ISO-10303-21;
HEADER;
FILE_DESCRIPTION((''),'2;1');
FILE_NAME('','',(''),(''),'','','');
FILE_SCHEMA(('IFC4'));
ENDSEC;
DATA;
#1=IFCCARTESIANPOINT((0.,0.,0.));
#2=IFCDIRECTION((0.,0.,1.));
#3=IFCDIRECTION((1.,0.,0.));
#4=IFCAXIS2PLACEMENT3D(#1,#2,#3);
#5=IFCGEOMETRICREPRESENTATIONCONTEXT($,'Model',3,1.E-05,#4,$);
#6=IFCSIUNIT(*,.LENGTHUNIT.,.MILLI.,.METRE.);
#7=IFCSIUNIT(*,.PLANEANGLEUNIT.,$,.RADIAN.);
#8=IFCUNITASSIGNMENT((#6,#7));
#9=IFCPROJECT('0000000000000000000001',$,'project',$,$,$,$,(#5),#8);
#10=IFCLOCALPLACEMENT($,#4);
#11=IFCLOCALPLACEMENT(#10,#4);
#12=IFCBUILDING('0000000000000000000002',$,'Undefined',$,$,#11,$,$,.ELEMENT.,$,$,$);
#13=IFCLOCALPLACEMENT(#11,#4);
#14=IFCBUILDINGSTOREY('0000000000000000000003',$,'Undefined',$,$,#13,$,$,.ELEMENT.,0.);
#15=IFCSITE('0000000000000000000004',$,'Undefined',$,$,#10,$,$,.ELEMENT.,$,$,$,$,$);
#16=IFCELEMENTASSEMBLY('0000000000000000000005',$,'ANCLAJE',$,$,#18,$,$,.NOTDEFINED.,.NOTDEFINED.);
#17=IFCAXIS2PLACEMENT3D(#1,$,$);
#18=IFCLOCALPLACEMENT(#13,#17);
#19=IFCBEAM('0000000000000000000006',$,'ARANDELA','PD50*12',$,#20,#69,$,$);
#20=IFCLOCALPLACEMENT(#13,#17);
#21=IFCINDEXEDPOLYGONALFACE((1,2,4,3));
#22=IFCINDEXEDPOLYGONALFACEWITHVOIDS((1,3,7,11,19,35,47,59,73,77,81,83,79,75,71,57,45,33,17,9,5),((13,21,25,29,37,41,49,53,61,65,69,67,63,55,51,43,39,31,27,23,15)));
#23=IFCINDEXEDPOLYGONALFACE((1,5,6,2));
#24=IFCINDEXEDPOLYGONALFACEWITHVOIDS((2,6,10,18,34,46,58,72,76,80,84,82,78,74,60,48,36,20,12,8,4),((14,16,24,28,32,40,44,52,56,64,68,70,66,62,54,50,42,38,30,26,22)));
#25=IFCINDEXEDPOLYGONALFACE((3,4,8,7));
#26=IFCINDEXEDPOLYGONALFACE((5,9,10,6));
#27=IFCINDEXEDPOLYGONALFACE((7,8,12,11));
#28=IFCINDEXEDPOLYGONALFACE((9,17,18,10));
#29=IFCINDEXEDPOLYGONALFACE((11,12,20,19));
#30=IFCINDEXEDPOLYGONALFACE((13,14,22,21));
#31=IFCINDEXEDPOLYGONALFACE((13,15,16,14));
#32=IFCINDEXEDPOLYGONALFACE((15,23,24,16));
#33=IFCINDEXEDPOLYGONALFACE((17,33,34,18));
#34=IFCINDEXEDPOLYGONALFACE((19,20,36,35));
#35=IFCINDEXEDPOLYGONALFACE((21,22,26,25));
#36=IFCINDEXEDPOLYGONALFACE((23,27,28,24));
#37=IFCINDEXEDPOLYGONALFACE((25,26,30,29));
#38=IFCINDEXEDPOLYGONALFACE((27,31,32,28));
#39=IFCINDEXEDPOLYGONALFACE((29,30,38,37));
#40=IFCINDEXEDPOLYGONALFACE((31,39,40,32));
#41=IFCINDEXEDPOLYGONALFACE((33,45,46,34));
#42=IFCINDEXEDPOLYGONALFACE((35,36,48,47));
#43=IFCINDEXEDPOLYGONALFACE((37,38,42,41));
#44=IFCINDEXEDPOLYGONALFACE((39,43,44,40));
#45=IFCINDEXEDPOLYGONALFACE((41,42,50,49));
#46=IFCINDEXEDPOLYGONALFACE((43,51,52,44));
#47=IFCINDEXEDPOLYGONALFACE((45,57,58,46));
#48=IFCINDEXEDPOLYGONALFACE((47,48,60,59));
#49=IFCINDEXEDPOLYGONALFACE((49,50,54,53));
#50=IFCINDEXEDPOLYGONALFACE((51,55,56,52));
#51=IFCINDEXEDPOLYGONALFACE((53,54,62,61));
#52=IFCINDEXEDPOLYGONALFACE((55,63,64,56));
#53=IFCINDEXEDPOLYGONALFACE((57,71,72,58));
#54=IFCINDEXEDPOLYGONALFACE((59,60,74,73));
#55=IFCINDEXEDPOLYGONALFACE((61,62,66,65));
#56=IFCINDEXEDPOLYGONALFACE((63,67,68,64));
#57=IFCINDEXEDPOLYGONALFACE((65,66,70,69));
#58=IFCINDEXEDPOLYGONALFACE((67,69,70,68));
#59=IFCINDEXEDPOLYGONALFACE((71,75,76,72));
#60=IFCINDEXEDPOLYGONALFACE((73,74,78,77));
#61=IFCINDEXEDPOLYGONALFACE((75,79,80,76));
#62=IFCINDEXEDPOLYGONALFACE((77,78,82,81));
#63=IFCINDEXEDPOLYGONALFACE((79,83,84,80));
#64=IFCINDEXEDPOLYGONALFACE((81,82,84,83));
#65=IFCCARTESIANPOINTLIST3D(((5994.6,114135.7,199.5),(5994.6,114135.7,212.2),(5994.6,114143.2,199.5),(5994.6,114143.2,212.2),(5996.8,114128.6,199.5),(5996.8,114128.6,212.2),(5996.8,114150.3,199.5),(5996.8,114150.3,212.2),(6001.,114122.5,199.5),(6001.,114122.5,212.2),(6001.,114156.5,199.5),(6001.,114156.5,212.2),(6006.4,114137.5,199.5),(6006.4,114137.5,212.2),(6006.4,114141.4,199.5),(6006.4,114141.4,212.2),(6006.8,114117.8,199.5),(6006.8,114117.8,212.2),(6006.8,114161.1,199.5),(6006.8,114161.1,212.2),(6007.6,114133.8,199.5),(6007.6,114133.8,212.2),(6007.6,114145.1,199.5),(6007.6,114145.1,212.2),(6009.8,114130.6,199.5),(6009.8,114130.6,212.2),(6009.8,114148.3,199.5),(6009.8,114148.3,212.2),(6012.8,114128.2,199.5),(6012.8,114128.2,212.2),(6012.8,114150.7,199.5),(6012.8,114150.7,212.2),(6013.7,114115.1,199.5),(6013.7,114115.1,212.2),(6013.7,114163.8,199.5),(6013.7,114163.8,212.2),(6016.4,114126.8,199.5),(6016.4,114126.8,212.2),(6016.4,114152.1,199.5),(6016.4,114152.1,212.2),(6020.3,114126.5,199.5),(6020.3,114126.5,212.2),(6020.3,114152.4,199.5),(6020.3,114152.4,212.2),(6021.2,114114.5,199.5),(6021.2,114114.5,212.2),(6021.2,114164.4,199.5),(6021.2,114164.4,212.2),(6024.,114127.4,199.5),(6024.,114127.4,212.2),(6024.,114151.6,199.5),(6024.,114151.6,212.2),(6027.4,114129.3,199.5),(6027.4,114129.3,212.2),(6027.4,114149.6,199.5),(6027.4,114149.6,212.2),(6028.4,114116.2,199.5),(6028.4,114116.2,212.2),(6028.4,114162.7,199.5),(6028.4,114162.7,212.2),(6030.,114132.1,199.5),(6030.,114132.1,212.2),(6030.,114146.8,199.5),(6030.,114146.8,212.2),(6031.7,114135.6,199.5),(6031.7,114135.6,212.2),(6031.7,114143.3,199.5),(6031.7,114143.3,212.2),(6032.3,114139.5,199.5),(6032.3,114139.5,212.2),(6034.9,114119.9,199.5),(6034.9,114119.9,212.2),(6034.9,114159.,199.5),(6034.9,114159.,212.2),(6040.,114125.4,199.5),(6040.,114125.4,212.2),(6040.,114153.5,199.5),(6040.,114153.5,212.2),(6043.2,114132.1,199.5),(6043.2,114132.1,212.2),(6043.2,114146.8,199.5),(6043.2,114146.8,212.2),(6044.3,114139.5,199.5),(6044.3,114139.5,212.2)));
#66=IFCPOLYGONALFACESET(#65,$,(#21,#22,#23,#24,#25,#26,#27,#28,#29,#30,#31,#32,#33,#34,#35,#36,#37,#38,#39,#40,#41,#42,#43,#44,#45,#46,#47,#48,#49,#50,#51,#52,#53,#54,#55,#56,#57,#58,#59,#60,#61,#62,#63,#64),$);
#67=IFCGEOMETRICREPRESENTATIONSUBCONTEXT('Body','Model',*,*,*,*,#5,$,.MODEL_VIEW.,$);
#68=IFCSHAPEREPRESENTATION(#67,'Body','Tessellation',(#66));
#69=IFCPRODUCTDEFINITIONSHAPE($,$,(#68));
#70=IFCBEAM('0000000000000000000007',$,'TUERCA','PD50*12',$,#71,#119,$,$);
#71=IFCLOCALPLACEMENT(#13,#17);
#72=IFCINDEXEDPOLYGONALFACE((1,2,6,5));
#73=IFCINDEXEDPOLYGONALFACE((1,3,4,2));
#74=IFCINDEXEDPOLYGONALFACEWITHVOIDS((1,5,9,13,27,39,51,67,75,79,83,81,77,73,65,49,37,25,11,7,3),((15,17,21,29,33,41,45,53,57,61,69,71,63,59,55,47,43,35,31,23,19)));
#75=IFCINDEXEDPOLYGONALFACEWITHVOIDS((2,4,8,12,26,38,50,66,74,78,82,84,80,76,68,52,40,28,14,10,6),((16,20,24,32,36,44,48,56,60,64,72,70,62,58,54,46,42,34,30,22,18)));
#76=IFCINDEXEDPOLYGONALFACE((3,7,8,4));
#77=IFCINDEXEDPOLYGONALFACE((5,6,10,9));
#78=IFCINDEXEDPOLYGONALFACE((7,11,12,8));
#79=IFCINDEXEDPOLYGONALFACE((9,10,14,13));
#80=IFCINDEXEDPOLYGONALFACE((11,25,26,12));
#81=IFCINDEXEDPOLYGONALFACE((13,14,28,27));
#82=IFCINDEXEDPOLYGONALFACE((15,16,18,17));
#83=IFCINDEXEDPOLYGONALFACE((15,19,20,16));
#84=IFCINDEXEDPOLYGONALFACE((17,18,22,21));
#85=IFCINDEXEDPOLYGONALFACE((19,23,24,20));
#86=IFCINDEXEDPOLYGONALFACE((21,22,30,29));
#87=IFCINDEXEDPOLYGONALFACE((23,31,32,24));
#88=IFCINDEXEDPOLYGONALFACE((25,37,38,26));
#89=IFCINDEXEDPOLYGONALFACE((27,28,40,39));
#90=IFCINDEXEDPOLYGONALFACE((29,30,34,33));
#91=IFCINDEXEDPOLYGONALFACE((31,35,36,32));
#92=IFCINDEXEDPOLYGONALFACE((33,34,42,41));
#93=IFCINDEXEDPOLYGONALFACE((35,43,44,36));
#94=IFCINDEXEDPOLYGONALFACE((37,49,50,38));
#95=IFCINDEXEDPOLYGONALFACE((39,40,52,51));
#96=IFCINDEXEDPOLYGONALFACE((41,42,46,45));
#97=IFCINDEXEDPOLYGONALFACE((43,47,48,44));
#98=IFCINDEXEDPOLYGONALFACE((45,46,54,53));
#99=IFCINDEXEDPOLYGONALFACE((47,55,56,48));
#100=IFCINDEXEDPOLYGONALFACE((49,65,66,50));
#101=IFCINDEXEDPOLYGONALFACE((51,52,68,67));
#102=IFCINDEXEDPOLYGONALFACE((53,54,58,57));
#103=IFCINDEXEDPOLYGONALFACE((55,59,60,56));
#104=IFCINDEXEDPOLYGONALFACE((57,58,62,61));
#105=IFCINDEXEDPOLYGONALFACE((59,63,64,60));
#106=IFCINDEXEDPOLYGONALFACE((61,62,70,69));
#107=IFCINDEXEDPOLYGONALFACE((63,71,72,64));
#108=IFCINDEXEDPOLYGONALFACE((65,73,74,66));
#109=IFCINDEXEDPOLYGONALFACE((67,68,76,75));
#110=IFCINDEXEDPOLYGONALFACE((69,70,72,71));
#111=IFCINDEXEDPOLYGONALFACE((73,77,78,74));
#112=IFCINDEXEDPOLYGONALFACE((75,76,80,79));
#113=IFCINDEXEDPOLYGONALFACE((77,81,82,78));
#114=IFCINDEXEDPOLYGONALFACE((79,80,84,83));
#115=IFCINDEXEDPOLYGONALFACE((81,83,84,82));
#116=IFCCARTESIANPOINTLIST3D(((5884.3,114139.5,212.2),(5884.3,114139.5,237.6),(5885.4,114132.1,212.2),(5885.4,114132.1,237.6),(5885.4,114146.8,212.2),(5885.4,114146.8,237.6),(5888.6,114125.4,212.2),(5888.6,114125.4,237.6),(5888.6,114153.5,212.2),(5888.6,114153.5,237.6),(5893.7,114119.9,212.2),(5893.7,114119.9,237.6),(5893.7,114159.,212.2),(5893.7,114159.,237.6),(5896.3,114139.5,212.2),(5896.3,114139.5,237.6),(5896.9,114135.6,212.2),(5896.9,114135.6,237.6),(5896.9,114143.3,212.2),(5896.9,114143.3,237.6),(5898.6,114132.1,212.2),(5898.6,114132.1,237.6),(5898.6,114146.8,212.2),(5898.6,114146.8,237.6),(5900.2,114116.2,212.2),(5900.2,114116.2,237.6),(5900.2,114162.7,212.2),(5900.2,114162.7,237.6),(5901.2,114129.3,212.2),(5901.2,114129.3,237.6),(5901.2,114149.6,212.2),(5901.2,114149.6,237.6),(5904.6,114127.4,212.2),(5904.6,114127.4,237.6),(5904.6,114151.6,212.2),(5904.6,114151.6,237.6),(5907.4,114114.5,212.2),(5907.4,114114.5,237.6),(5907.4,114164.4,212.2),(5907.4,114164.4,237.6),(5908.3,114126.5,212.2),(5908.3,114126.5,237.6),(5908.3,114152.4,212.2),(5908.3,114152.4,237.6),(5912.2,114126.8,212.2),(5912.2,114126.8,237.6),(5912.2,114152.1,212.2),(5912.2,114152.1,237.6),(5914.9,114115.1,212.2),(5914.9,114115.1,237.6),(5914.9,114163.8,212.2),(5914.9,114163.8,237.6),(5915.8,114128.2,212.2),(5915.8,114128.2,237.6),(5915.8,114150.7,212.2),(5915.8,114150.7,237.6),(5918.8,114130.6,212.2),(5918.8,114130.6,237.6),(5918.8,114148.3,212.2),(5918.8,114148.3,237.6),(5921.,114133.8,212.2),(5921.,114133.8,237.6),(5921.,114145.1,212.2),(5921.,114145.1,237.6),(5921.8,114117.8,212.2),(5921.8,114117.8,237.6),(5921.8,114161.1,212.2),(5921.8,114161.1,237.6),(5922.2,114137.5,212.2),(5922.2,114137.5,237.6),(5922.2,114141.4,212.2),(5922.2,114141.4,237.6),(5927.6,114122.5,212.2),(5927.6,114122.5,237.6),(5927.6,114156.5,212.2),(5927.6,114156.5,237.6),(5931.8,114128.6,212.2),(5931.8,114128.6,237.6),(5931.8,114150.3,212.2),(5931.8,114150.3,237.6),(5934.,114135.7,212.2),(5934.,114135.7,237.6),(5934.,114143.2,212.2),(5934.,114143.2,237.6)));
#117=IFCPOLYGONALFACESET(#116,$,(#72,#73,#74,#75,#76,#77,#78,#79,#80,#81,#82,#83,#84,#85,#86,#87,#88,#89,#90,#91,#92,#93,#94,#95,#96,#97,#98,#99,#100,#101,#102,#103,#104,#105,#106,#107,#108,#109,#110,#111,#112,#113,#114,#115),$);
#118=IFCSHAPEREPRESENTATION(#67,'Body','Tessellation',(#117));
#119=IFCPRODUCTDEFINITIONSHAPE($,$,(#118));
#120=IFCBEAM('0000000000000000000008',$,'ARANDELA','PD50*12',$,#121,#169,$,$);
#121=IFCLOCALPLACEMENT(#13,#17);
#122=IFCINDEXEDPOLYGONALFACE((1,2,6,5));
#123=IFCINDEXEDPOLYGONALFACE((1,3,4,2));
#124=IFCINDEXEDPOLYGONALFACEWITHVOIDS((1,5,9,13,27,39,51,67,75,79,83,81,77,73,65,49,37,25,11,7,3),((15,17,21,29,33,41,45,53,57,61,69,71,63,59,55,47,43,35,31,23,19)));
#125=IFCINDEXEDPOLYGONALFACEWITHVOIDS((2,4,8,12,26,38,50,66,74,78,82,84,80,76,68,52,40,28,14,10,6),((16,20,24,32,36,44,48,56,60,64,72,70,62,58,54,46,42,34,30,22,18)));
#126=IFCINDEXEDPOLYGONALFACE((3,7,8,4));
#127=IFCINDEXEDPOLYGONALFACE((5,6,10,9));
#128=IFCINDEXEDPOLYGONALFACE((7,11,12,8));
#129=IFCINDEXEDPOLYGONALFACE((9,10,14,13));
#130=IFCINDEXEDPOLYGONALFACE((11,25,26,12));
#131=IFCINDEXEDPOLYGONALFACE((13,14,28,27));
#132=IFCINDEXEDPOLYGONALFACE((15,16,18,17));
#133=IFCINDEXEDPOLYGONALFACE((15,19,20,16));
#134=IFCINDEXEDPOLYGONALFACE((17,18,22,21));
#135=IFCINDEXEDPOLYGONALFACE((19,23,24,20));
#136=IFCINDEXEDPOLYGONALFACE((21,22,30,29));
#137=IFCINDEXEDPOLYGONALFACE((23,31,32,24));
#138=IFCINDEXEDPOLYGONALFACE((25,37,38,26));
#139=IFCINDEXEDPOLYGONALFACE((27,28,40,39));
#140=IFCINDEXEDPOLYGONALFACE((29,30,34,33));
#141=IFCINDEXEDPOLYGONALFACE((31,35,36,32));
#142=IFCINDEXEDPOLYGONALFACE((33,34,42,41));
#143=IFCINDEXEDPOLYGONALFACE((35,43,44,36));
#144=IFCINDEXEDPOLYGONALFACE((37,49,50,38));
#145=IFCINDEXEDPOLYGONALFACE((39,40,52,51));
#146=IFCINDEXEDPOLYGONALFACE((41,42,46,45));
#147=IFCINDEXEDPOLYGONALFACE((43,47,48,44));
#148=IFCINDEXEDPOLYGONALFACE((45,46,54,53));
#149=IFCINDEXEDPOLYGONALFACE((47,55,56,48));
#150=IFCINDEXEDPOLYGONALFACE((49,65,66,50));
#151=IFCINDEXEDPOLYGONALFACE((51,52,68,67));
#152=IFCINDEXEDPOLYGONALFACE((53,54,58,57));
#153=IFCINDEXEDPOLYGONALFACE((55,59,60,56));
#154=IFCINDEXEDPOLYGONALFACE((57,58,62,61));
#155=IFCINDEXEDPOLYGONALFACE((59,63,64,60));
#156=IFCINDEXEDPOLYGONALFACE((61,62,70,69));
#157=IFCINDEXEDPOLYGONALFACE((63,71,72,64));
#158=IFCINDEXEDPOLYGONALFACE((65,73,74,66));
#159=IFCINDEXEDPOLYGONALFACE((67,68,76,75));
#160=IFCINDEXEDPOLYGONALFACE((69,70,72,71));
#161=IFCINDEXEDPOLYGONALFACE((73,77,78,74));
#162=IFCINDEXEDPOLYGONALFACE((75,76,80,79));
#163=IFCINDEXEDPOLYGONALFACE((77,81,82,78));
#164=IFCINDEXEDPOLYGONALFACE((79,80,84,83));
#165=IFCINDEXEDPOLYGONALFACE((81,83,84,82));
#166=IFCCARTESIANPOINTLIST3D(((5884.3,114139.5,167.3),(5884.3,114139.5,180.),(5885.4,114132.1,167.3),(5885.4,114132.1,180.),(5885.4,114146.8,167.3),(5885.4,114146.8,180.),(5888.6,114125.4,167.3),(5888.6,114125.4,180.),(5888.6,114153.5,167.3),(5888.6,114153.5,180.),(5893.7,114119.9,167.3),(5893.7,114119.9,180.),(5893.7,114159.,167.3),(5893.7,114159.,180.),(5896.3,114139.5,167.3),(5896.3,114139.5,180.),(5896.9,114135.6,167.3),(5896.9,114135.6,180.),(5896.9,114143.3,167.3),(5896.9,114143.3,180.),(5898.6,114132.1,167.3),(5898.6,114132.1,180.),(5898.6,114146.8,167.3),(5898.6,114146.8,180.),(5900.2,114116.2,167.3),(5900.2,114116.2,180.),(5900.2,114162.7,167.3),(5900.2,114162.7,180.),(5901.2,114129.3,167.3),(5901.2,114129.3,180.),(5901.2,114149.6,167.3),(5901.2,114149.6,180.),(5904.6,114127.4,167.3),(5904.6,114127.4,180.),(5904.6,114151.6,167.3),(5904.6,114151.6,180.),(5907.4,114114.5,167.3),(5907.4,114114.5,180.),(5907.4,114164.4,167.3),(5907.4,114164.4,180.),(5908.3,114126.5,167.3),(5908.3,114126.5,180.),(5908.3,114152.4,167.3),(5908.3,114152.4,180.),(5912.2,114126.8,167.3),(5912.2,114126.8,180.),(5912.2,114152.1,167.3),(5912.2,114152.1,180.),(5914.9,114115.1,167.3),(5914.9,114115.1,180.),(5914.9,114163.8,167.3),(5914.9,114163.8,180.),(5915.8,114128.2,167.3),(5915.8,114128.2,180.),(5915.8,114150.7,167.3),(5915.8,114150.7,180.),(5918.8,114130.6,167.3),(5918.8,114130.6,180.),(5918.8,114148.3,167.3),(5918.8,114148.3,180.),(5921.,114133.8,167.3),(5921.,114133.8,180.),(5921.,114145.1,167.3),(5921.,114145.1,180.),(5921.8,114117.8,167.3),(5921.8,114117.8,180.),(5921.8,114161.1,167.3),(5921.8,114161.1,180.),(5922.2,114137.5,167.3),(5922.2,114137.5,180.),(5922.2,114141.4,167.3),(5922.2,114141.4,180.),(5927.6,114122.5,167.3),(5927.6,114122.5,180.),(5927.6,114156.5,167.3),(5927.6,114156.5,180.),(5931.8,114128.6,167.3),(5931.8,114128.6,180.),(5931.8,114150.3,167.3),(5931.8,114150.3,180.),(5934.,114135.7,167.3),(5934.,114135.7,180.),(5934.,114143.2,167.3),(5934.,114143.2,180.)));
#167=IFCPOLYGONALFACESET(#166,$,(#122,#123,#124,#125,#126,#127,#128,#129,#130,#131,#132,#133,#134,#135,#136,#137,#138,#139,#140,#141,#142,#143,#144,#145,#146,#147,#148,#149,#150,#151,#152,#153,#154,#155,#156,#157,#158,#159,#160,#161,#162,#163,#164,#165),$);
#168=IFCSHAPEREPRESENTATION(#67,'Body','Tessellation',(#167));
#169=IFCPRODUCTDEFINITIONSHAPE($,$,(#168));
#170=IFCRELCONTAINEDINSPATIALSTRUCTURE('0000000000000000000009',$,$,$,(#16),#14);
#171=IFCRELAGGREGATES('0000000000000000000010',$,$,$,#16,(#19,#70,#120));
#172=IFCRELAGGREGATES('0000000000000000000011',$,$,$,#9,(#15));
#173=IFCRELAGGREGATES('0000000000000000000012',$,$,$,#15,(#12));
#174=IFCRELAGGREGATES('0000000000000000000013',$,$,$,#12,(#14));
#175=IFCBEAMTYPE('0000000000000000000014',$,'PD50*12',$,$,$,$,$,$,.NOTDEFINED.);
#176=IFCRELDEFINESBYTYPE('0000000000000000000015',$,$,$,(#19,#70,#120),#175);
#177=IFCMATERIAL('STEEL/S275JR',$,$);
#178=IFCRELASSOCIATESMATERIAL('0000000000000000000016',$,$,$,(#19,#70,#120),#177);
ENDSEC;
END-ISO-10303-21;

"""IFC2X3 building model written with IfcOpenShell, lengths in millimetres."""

from ifc_helpers import new_model, si_unit, frame, origin_with_axes, origin_2d_with_axis, place, context, subcontext, project, spatial, hollow_circle, extrude, material, type_object, element, aggregate, save


model = new_model("IFC2X3")

# Units and contexts
model_context = context("Model", 3, precision=1e-05, world=origin_with_axes())
body_context = subcontext(model_context, "Body", "Model", "MODEL_VIEW")
ifc_project = project(units=[si_unit("LENGTHUNIT", "METRE", prefix="MILLI"), si_unit("PLANEANGLEUNIT", "RADIAN")], contexts=[model_context])

# Site, building, storey
site_placement = place(None, origin_with_axes())
site = spatial("IfcSite", under=ifc_project, at=site_placement, Name="Undefined", CompositionType="ELEMENT")
building_placement = place(site_placement, origin_with_axes())
building = spatial("IfcBuilding", under=site, at=building_placement, Name="Undefined", CompositionType="ELEMENT")
storey_placement = place(building_placement, origin_with_axes())
storey = spatial("IfcBuildingStorey", under=building, at=storey_placement, Name="Undefined", CompositionType="ELEMENT", Elevation=0.0)

# Element assembly, beams
assembly_1_placement = place(storey_placement, origin_with_axes())
assembly_1 = element("IfcElementAssembly", 1, at=assembly_1_placement, inside=storey, Name="ANCLAJE", AssemblyPlace="NOTDEFINED", PredefinedType="NOTDEFINED")
ifc_material_1 = material(Name="STEEL/S275JR")
beam_type_1 = type_object("IfcBeamType", Name="PD50*12", PredefinedType="NOTDEFINED")
beam_1_placement = place(assembly_1_placement, frame((6019.3, 114139.5, 212.2), z_axis=(0.0, 1.0, 0.0), x_axis=(0.0, 0.0, -1.0)))
beam_1 = element("IfcBeam", 2, at=beam_1_placement, type_object=beam_type_1, material=ifc_material_1, Name="ARANDELA", Description="PD50*12", context=body_context, shape_type="SweptSolid", body=[
    extrude(hollow_circle(Radius=25.0, WallThickness=12.0, at=origin_2d_with_axis()), frame((12.7, 0.0, 0.0), z_axis=(-1.0, 0.0, 0.0), x_axis=(0.0, -1.0, 0.0)), (0.0, 0.0, 1.0), 12.7),
])
beam_2_placement = place(assembly_1_placement, frame((5909.3, 114139.5, 237.6), z_axis=(0.0, -1.0, 0.0), x_axis=(0.0, 0.0, -1.0)))
beam_2 = element("IfcBeam", 3, at=beam_2_placement, type_object=beam_type_1, material=ifc_material_1, Name="TUERCA", Description="PD50*12", context=body_context, shape_type="SweptSolid", body=[
    extrude(hollow_circle(Radius=25.0, WallThickness=12.0, at=origin_2d_with_axis()), frame((25.4, 0.0, 0.0), z_axis=(-1.0, 0.0, 0.0), x_axis=(0.0, -1.0, 0.0)), (0.0, 0.0, 1.0), 25.4),
])
beam_3_placement = place(assembly_1_placement, frame((5909.3, 114139.5, 180.0), z_axis=(0.0, -1.0, 0.0), x_axis=(0.0, 0.0, -1.0)))
beam_3 = element("IfcBeam", 4, at=beam_3_placement, type_object=beam_type_1, material=ifc_material_1, Name="ARANDELA", Description="PD50*12", context=body_context, shape_type="SweptSolid", body=[
    extrude(hollow_circle(Radius=25.0, WallThickness=12.0, at=origin_2d_with_axis()), frame((12.7, 0.0, 0.0), z_axis=(-1.0, 0.0, 0.0), x_axis=(0.0, -1.0, 0.0)), (0.0, 0.0, 1.0), 12.7),
])

aggregate(assembly_1, [beam_1, beam_2, beam_3])

save(model, "model.ifc")
